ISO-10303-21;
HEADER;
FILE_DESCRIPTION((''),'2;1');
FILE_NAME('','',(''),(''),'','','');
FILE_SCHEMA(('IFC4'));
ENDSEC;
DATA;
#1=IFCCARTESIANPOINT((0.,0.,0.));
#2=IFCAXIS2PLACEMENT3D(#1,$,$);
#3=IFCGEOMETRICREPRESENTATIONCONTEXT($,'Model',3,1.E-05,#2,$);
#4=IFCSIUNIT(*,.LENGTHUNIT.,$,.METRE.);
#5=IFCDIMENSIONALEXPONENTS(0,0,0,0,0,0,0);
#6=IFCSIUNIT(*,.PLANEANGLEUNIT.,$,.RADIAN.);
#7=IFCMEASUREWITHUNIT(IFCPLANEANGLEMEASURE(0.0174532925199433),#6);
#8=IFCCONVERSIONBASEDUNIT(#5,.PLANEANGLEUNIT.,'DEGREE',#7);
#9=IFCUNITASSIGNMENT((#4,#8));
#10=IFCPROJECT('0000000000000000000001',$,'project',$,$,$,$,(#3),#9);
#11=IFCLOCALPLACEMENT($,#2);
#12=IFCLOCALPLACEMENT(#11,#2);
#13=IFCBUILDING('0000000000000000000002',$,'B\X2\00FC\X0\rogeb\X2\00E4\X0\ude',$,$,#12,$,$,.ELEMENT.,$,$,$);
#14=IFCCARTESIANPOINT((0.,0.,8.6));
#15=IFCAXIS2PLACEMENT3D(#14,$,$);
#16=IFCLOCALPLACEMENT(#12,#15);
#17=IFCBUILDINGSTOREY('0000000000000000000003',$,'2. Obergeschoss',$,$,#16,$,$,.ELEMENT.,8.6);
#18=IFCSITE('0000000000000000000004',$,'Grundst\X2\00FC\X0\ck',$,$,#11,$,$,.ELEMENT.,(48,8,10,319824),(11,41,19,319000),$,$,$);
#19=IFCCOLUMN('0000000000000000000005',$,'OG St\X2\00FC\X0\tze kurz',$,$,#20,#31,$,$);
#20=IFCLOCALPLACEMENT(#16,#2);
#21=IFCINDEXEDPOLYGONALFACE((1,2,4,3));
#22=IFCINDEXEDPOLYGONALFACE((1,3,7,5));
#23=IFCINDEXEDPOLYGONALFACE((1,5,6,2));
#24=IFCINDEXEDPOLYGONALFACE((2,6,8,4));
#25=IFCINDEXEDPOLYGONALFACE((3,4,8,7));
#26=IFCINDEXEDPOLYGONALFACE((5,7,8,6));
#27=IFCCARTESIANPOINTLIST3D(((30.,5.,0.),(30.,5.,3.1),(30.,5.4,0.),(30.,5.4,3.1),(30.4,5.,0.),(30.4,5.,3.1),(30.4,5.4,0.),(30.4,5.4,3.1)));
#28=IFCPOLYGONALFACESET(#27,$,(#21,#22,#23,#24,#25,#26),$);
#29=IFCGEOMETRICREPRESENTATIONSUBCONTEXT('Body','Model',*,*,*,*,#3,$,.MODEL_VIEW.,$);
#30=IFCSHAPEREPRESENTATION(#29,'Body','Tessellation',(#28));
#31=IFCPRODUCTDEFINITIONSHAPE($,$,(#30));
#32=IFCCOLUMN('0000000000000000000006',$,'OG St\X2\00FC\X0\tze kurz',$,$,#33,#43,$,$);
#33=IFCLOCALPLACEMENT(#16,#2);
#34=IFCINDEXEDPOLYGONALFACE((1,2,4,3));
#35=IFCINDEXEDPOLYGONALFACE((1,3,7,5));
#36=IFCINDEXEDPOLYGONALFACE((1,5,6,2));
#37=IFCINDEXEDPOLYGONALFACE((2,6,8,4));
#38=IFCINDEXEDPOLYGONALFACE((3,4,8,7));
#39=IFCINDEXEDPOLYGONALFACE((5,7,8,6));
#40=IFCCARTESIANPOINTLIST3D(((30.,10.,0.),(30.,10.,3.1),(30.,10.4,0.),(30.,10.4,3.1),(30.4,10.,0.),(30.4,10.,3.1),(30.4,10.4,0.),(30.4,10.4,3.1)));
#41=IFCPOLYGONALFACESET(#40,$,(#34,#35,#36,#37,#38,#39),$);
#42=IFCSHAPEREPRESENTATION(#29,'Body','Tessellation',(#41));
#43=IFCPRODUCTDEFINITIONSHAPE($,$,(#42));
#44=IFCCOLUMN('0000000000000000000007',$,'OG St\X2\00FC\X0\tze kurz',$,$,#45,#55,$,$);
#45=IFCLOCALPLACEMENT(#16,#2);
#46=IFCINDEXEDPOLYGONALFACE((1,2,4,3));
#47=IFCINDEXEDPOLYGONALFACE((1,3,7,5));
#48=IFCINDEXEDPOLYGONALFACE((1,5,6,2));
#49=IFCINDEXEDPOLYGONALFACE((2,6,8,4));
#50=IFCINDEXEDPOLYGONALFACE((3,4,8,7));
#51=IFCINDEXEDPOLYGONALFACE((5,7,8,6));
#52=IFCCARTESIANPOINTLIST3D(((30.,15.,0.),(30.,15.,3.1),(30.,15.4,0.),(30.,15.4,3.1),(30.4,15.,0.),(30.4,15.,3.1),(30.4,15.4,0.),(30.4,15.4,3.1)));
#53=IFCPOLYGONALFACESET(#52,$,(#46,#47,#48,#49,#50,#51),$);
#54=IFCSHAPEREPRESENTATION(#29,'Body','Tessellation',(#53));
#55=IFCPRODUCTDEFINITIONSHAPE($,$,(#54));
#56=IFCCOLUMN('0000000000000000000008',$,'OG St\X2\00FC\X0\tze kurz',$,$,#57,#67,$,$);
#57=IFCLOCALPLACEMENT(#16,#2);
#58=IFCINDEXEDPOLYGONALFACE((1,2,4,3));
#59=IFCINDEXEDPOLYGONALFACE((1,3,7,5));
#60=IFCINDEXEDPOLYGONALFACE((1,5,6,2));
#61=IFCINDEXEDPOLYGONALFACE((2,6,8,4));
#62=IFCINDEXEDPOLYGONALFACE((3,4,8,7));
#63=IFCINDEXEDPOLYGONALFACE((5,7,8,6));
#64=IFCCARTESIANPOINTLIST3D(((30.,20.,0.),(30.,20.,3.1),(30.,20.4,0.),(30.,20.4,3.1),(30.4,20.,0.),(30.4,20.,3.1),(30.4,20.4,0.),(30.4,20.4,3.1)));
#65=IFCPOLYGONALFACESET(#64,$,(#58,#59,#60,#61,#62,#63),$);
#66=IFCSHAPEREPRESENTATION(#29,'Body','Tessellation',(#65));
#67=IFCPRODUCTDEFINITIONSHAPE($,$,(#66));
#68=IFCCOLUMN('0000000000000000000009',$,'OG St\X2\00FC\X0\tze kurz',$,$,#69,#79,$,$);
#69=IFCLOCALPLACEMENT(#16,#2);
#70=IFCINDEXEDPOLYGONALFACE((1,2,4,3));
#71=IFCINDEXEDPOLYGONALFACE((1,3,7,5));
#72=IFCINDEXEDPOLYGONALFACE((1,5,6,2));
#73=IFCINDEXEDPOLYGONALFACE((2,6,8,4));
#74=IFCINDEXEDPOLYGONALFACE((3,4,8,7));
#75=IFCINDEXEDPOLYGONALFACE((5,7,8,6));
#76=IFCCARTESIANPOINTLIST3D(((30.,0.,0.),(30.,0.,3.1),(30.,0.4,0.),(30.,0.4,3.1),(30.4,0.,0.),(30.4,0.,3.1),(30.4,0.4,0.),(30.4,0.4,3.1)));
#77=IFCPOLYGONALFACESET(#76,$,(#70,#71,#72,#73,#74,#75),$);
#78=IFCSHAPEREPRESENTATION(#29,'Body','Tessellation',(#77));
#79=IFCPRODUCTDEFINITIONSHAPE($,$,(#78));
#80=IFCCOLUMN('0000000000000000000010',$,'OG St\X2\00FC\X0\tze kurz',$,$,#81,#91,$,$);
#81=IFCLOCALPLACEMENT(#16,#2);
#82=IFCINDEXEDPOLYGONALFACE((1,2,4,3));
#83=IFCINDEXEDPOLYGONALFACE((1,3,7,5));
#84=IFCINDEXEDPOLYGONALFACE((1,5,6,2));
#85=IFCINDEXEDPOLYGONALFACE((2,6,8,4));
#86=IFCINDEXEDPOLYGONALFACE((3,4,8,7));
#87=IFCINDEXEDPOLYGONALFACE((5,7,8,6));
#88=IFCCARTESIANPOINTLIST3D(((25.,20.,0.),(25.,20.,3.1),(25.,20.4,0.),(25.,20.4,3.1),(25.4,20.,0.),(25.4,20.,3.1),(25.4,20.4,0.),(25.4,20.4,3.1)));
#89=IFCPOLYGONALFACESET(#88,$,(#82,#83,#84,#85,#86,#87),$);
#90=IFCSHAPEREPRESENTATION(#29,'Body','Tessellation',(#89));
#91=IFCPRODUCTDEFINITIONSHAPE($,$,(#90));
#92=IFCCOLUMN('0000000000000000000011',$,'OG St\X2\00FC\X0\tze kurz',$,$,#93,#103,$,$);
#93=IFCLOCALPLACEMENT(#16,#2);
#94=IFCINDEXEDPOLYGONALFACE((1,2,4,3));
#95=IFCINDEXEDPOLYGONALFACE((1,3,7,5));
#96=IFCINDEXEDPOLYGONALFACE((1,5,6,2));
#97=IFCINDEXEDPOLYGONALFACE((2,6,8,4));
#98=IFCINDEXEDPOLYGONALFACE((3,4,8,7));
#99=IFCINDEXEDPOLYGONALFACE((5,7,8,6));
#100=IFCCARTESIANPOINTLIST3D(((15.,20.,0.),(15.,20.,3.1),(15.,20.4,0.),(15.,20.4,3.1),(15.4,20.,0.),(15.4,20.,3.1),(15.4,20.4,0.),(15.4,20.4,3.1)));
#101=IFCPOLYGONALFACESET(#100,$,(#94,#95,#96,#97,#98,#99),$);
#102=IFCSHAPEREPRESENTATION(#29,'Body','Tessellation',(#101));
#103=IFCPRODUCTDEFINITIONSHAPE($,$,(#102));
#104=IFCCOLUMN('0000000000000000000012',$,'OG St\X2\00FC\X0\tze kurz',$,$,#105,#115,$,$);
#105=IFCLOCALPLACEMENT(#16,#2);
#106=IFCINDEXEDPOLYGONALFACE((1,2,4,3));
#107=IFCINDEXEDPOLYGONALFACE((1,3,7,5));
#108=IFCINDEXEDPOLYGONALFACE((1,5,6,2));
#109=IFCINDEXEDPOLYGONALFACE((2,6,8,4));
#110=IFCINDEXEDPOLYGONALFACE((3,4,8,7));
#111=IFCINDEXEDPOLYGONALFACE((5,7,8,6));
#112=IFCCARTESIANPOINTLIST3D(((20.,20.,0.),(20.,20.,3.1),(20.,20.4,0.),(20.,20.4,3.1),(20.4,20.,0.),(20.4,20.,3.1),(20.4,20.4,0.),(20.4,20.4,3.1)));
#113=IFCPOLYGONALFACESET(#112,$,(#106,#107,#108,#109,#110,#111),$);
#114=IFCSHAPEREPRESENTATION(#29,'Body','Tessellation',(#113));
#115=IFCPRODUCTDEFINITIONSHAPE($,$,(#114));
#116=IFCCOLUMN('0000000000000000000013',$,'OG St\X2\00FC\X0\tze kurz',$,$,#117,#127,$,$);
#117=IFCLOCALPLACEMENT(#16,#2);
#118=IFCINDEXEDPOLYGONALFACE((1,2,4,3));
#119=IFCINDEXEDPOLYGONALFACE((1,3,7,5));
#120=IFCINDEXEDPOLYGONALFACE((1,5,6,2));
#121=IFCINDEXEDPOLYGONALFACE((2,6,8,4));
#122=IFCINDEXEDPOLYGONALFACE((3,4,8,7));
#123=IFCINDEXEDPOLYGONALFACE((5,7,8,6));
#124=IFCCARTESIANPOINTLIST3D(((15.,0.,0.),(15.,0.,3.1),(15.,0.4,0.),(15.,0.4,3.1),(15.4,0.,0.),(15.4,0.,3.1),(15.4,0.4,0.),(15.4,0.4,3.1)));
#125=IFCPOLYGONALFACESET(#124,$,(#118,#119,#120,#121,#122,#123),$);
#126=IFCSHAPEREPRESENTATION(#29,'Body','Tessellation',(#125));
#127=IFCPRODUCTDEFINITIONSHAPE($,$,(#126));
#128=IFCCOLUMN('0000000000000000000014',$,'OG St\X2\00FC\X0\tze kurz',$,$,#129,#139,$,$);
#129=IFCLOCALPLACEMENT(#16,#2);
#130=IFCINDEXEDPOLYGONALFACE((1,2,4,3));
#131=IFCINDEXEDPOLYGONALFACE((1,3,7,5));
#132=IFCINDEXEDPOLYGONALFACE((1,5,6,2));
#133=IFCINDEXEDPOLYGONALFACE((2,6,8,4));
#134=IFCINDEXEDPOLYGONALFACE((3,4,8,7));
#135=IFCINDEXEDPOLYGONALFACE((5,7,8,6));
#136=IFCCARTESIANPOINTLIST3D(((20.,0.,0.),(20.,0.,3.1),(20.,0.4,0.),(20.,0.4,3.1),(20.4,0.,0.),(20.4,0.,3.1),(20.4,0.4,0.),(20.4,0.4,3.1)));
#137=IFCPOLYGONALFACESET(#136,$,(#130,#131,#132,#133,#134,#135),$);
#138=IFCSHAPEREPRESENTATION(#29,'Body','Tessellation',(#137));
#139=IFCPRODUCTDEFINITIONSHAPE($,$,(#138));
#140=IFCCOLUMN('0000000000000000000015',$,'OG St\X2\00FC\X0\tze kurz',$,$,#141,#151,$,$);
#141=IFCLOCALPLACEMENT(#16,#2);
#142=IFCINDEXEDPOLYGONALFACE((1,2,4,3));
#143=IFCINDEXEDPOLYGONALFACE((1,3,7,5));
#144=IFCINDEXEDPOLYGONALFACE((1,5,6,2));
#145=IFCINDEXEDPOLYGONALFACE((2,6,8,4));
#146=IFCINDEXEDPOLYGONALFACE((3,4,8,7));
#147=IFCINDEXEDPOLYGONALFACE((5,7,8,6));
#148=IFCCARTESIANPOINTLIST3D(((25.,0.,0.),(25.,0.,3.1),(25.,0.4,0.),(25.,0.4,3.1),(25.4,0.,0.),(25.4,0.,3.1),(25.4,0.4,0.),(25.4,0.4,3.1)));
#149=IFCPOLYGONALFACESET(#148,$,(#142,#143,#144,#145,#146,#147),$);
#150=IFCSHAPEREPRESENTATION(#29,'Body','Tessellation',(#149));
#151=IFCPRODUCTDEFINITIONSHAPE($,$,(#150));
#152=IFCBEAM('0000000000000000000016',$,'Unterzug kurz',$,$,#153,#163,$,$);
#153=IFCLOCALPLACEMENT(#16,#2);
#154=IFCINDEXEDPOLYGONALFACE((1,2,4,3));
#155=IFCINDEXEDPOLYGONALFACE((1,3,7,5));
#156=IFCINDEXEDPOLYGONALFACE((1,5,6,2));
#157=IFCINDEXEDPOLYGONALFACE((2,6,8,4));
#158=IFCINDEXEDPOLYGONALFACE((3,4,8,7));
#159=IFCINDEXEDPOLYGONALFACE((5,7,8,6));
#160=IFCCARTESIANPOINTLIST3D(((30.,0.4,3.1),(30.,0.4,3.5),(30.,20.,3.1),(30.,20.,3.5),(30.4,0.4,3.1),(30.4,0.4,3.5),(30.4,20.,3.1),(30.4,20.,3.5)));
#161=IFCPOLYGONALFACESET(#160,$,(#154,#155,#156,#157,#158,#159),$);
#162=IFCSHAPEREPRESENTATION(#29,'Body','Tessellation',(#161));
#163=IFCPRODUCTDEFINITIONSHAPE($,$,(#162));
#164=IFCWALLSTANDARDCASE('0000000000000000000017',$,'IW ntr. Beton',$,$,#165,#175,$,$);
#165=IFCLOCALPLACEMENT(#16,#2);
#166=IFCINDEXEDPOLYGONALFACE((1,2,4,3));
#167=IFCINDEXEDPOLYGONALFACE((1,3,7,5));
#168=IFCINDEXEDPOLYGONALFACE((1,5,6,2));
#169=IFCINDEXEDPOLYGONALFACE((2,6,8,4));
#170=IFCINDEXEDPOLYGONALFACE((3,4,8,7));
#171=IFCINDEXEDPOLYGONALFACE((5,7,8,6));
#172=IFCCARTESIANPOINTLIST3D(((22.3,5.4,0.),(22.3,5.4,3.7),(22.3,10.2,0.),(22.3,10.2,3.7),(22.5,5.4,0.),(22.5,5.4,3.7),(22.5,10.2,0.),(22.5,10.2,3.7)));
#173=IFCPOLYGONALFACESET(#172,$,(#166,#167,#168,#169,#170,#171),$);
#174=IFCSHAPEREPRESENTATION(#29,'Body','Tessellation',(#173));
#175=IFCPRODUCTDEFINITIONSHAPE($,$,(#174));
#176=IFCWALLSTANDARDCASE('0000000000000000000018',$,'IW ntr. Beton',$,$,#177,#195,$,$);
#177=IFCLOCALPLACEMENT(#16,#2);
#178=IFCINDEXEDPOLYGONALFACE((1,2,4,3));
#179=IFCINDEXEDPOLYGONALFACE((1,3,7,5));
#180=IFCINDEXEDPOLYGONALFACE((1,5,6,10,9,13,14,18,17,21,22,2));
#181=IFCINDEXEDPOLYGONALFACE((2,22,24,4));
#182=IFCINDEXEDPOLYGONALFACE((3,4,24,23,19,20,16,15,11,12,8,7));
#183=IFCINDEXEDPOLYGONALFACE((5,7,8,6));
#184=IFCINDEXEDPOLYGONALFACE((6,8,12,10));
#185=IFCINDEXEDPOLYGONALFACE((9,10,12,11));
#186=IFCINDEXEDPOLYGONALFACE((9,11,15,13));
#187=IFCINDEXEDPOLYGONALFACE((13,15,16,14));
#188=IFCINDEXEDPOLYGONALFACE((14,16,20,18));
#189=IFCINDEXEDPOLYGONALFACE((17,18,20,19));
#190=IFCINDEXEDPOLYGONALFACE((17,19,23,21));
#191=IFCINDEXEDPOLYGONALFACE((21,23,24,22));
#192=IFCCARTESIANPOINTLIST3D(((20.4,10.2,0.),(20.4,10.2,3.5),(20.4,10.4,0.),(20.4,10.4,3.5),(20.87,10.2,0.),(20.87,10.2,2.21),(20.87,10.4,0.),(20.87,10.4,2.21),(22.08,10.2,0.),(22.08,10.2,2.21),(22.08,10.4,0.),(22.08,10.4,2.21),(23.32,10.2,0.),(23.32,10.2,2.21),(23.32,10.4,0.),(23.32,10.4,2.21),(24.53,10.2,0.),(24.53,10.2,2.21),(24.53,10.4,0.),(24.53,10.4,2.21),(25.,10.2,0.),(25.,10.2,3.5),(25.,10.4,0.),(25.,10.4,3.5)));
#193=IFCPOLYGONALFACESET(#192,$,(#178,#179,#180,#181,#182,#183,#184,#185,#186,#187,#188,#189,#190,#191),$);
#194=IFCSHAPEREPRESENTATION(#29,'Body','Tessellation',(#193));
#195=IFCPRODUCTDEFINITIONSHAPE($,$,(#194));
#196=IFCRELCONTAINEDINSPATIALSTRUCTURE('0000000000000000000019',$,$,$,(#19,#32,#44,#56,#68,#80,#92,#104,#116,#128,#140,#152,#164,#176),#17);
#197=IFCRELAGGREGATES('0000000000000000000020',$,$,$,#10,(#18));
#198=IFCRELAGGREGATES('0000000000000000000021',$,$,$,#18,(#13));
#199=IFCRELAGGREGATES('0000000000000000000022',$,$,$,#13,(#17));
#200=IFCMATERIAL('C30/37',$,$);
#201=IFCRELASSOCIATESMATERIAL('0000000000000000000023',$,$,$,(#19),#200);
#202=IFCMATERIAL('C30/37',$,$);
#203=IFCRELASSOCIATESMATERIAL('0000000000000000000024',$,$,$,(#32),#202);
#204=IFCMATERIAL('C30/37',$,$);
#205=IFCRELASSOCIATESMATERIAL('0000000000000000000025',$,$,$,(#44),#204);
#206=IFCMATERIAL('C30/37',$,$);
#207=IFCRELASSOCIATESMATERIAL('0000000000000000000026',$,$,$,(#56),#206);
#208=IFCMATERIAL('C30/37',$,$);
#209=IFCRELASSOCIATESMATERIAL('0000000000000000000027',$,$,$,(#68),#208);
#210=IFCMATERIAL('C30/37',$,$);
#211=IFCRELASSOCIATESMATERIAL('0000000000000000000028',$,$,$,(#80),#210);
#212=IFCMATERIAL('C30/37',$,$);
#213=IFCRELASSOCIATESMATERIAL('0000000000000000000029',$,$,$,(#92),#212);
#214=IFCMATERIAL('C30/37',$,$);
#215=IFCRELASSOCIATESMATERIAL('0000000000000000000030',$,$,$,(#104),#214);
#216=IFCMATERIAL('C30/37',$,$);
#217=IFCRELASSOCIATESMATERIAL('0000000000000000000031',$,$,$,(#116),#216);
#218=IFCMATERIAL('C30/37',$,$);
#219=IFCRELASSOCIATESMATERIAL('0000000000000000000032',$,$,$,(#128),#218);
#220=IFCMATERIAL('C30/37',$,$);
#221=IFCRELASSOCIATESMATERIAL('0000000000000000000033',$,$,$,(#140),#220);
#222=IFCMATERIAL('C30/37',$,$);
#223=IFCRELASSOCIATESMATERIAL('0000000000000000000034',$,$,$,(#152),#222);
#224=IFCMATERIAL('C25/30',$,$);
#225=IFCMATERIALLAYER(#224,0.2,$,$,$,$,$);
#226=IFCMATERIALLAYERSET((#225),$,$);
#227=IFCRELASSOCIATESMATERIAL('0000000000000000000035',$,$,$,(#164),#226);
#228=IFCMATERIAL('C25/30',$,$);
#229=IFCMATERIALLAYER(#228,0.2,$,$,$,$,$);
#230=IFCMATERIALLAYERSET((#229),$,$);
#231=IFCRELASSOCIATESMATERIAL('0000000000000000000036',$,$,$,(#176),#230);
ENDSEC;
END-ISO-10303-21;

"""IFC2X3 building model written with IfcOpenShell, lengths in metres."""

from ifc_helpers import new_model, entity, si_unit, converted_unit, frame, frame_2d, origin, origin_with_axes, place, context, subcontext, project, spatial, polyline, rectangle, outline, extrude, material, layer, layer_set, layer_usage, element, save


model = new_model("IFC2X3")

# Units and contexts
model_context = context("Model", 3, precision=1e-05, world=origin())
body_context = subcontext(model_context, "Body", "Model", "MODEL_VIEW")
ifc_project = project(units=[si_unit("LENGTHUNIT", "METRE"), converted_unit("PLANEANGLEUNIT", "DEGREE", entity("IfcPlaneAngleMeasure", 0.0174532925199433), si_unit("PLANEANGLEUNIT", "RADIAN"), dimensions=[0, 0, 0, 0, 0, 0, 0])], contexts=[model_context])

# Site, building, storey
site_placement = place(None, origin())
site = spatial("IfcSite", under=ifc_project, at=site_placement, Name="Grundstück", CompositionType="ELEMENT", RefLatitude=(48, 8, 10, 319824), RefLongitude=(11, 41, 19, 319000))
building_placement = place(site_placement, origin())
building = spatial("IfcBuilding", under=site, at=building_placement, Name="Bürogebäude", CompositionType="ELEMENT")
storey_placement = place(building_placement, frame((0.0, 0.0, 8.6)))
storey = spatial("IfcBuildingStorey", under=building, at=storey_placement, Name="2. Obergeschoss", CompositionType="ELEMENT", Elevation=8.6)

# Columns
ifc_material_1 = material(Name="C30/37")
column_1_placement = place(storey_placement, frame((30.0, 5.0, 0.0)))
element("IfcColumn", 1, at=column_1_placement, inside=storey, material=ifc_material_1, Name="OG Stütze kurz", context=body_context, shape_type="SweptSolid", body=[
    extrude(rectangle(XDim=0.4, YDim=0.4, at=frame_2d((0.2, 0.2), x_axis=(1.0, 0.0))), origin_with_axes(), (0.0, 0.0, 1.0), 3.1),
])
ifc_material_2 = material(Name="C30/37")
column_2_placement = place(storey_placement, frame((30.0, 10.0, 0.0)))
element("IfcColumn", 2, at=column_2_placement, inside=storey, material=ifc_material_2, Name="OG Stütze kurz", context=body_context, shape_type="SweptSolid", body=[
    extrude(rectangle(XDim=0.4, YDim=0.4, at=frame_2d((0.2, 0.2), x_axis=(1.0, 0.0))), origin_with_axes(), (0.0, 0.0, 1.0), 3.1),
])
ifc_material_3 = material(Name="C30/37")
column_3_placement = place(storey_placement, frame((30.0, 15.0, 0.0)))
element("IfcColumn", 3, at=column_3_placement, inside=storey, material=ifc_material_3, Name="OG Stütze kurz", context=body_context, shape_type="SweptSolid", body=[
    extrude(rectangle(XDim=0.4, YDim=0.4, at=frame_2d((0.2, 0.2), x_axis=(1.0, 0.0))), origin_with_axes(), (0.0, 0.0, 1.0), 3.1),
])
ifc_material_4 = material(Name="C30/37")
column_4_placement = place(storey_placement, frame((30.0, 20.0, 0.0)))
element("IfcColumn", 4, at=column_4_placement, inside=storey, material=ifc_material_4, Name="OG Stütze kurz", context=body_context, shape_type="SweptSolid", body=[
    extrude(rectangle(XDim=0.4, YDim=0.4, at=frame_2d((0.2, 0.2), x_axis=(1.0, 0.0))), origin_with_axes(), (0.0, 0.0, 1.0), 3.1),
])
ifc_material_5 = material(Name="C30/37")
column_5_placement = place(storey_placement, frame((30.0, 0.0, 0.0)))
element("IfcColumn", 5, at=column_5_placement, inside=storey, material=ifc_material_5, Name="OG Stütze kurz", context=body_context, shape_type="SweptSolid", body=[
    extrude(rectangle(XDim=0.4, YDim=0.4, at=frame_2d((0.2, 0.2), x_axis=(1.0, 0.0))), origin_with_axes(), (0.0, 0.0, 1.0), 3.1),
])
ifc_material_6 = material(Name="C30/37")
column_6_placement = place(storey_placement, frame((25.0, 20.0, 0.0)))
element("IfcColumn", 6, at=column_6_placement, inside=storey, material=ifc_material_6, Name="OG Stütze kurz", context=body_context, shape_type="SweptSolid", body=[
    extrude(rectangle(XDim=0.4, YDim=0.4, at=frame_2d((0.2, 0.2), x_axis=(1.0, 0.0))), origin_with_axes(), (0.0, 0.0, 1.0), 3.1),
])
ifc_material_7 = material(Name="C30/37")
column_7_placement = place(storey_placement, frame((15.0, 20.0, 0.0)))
element("IfcColumn", 7, at=column_7_placement, inside=storey, material=ifc_material_7, Name="OG Stütze kurz", context=body_context, shape_type="SweptSolid", body=[
    extrude(rectangle(XDim=0.4, YDim=0.4, at=frame_2d((0.2, 0.2), x_axis=(1.0, 0.0))), origin_with_axes(), (0.0, 0.0, 1.0), 3.1),
])
ifc_material_8 = material(Name="C30/37")
column_8_placement = place(storey_placement, frame((20.0, 20.0, 0.0)))
element("IfcColumn", 8, at=column_8_placement, inside=storey, material=ifc_material_8, Name="OG Stütze kurz", context=body_context, shape_type="SweptSolid", body=[
    extrude(rectangle(XDim=0.4, YDim=0.4, at=frame_2d((0.2, 0.2), x_axis=(1.0, 0.0))), origin_with_axes(), (0.0, 0.0, 1.0), 3.1),
])
ifc_material_9 = material(Name="C30/37")
column_9_placement = place(storey_placement, frame((15.0, 0.0, 0.0)))
element("IfcColumn", 9, at=column_9_placement, inside=storey, material=ifc_material_9, Name="OG Stütze kurz", context=body_context, shape_type="SweptSolid", body=[
    extrude(rectangle(XDim=0.4, YDim=0.4, at=frame_2d((0.2, 0.2), x_axis=(1.0, 0.0))), origin_with_axes(), (0.0, 0.0, 1.0), 3.1),
])
ifc_material_10 = material(Name="C30/37")
column_10_placement = place(storey_placement, frame((20.0, 0.0, 0.0)))
element("IfcColumn", 10, at=column_10_placement, inside=storey, material=ifc_material_10, Name="OG Stütze kurz", context=body_context, shape_type="SweptSolid", body=[
    extrude(rectangle(XDim=0.4, YDim=0.4, at=frame_2d((0.2, 0.2), x_axis=(1.0, 0.0))), origin_with_axes(), (0.0, 0.0, 1.0), 3.1),
])
ifc_material_11 = material(Name="C30/37")
column_11_placement = place(storey_placement, frame((25.0, 0.0, 0.0)))
element("IfcColumn", 11, at=column_11_placement, inside=storey, material=ifc_material_11, Name="OG Stütze kurz", context=body_context, shape_type="SweptSolid", body=[
    extrude(rectangle(XDim=0.4, YDim=0.4, at=frame_2d((0.2, 0.2), x_axis=(1.0, 0.0))), origin_with_axes(), (0.0, 0.0, 1.0), 3.1),
])

# Beam
ifc_material_12 = material(Name="C30/37")
beam_placement = place(storey_placement, frame((30.4, 0.4, 3.1), z_axis=(0.0, 0.0, 1.0), x_axis=(0.0, 1.0, 0.0)))
element("IfcBeam", 12, at=beam_placement, inside=storey, material=ifc_material_12, Name="Unterzug kurz", context=body_context, shape_type="SweptSolid", body=[
    extrude(rectangle(XDim=0.4, YDim=0.4, at=frame_2d((0.2, 0.2), x_axis=(1.0, 0.0))), frame((0.0, 0.0, 0.0), z_axis=(1.0, 0.0, 0.0), x_axis=(0.0, 1.0, 0.0)), (0.0, 0.0, 1.0), 19.6),
])

# Wall
ifc_material_13 = material(Name="C25/30")
ifc_layer_1 = layer(ifc_material_13, 0.2)
ifc_layer_set_1 = layer_set([ifc_layer_1])
ifc_layer_usage_1 = layer_usage(ifc_layer_set_1, "AXIS2", "POSITIVE", -0.2)
wall_1_placement = place(storey_placement, frame((22.3, 10.2, 0.0), z_axis=(0.0, 0.0, 1.0), x_axis=(0.0, -1.0, 0.0)))
element("IfcWallStandardCase", 13, at=wall_1_placement, inside=storey, material=ifc_layer_usage_1, Name="IW ntr. Beton", context=body_context, shape_type="SweptSolid", body=[
    extrude(rectangle(XDim=4.8, YDim=0.2, at=frame_2d((2.4, 0.1), x_axis=(1.0, 0.0))), origin_with_axes(), (0.0, 0.0, 1.0), 3.7),
])

# Wall, openings
ifc_material_14 = material(Name="C25/30")
ifc_layer_2 = layer(ifc_material_14, 0.2)
ifc_layer_set_2 = layer_set([ifc_layer_2])
ifc_layer_usage_2 = layer_usage(ifc_layer_set_2, "AXIS2", "POSITIVE", -0.2)
wall_2_placement = place(storey_placement, frame((25.0, 10.4, 0.0), z_axis=(0.0, 0.0, 1.0), x_axis=(-1.0, 0.0, 0.0)))
wall_2 = element("IfcWallStandardCase", 14, at=wall_2_placement, inside=storey, material=ifc_layer_usage_2, Name="IW ntr. Beton", context=body_context, shape_type="SweptSolid", body=[
    extrude(rectangle(XDim=4.6, YDim=0.2, at=frame_2d((2.3, 0.1), x_axis=(1.0, 0.0))), origin_with_axes(), (0.0, 0.0, 1.0), 3.5),
])
opening_1_placement = place(wall_2_placement, frame((1.68, 0.2, 0.0), z_axis=(0.0, -1.0, 0.0), x_axis=(0.0, 0.0, 1.0)))
element("IfcOpeningElement", 15, at=opening_1_placement, cuts=wall_2, ObjectType="Opening", context=body_context, shape_type="SweptSolid", body=[
    extrude(outline(polyline([(0.0, 1.21), (2.21, 1.21), (2.21, 0.0), (0.0, 0.0), (0.0, 1.21)])), origin_with_axes(), (0.0, 0.0, 1.0), 0.2),
])
opening_2_placement = place(wall_2_placement, frame((4.13, 0.2, 0.0), z_axis=(0.0, -1.0, 0.0), x_axis=(0.0, 0.0, 1.0)))
element("IfcOpeningElement", 16, at=opening_2_placement, cuts=wall_2, ObjectType="Opening", context=body_context, shape_type="SweptSolid", body=[
    extrude(outline(polyline([(0.0, 1.21), (2.21, 1.21), (2.21, 0.0), (0.0, 0.0), (0.0, 1.21)])), origin_with_axes(), (0.0, 0.0, 1.0), 0.2),
])

save(model, "model.ifc")
